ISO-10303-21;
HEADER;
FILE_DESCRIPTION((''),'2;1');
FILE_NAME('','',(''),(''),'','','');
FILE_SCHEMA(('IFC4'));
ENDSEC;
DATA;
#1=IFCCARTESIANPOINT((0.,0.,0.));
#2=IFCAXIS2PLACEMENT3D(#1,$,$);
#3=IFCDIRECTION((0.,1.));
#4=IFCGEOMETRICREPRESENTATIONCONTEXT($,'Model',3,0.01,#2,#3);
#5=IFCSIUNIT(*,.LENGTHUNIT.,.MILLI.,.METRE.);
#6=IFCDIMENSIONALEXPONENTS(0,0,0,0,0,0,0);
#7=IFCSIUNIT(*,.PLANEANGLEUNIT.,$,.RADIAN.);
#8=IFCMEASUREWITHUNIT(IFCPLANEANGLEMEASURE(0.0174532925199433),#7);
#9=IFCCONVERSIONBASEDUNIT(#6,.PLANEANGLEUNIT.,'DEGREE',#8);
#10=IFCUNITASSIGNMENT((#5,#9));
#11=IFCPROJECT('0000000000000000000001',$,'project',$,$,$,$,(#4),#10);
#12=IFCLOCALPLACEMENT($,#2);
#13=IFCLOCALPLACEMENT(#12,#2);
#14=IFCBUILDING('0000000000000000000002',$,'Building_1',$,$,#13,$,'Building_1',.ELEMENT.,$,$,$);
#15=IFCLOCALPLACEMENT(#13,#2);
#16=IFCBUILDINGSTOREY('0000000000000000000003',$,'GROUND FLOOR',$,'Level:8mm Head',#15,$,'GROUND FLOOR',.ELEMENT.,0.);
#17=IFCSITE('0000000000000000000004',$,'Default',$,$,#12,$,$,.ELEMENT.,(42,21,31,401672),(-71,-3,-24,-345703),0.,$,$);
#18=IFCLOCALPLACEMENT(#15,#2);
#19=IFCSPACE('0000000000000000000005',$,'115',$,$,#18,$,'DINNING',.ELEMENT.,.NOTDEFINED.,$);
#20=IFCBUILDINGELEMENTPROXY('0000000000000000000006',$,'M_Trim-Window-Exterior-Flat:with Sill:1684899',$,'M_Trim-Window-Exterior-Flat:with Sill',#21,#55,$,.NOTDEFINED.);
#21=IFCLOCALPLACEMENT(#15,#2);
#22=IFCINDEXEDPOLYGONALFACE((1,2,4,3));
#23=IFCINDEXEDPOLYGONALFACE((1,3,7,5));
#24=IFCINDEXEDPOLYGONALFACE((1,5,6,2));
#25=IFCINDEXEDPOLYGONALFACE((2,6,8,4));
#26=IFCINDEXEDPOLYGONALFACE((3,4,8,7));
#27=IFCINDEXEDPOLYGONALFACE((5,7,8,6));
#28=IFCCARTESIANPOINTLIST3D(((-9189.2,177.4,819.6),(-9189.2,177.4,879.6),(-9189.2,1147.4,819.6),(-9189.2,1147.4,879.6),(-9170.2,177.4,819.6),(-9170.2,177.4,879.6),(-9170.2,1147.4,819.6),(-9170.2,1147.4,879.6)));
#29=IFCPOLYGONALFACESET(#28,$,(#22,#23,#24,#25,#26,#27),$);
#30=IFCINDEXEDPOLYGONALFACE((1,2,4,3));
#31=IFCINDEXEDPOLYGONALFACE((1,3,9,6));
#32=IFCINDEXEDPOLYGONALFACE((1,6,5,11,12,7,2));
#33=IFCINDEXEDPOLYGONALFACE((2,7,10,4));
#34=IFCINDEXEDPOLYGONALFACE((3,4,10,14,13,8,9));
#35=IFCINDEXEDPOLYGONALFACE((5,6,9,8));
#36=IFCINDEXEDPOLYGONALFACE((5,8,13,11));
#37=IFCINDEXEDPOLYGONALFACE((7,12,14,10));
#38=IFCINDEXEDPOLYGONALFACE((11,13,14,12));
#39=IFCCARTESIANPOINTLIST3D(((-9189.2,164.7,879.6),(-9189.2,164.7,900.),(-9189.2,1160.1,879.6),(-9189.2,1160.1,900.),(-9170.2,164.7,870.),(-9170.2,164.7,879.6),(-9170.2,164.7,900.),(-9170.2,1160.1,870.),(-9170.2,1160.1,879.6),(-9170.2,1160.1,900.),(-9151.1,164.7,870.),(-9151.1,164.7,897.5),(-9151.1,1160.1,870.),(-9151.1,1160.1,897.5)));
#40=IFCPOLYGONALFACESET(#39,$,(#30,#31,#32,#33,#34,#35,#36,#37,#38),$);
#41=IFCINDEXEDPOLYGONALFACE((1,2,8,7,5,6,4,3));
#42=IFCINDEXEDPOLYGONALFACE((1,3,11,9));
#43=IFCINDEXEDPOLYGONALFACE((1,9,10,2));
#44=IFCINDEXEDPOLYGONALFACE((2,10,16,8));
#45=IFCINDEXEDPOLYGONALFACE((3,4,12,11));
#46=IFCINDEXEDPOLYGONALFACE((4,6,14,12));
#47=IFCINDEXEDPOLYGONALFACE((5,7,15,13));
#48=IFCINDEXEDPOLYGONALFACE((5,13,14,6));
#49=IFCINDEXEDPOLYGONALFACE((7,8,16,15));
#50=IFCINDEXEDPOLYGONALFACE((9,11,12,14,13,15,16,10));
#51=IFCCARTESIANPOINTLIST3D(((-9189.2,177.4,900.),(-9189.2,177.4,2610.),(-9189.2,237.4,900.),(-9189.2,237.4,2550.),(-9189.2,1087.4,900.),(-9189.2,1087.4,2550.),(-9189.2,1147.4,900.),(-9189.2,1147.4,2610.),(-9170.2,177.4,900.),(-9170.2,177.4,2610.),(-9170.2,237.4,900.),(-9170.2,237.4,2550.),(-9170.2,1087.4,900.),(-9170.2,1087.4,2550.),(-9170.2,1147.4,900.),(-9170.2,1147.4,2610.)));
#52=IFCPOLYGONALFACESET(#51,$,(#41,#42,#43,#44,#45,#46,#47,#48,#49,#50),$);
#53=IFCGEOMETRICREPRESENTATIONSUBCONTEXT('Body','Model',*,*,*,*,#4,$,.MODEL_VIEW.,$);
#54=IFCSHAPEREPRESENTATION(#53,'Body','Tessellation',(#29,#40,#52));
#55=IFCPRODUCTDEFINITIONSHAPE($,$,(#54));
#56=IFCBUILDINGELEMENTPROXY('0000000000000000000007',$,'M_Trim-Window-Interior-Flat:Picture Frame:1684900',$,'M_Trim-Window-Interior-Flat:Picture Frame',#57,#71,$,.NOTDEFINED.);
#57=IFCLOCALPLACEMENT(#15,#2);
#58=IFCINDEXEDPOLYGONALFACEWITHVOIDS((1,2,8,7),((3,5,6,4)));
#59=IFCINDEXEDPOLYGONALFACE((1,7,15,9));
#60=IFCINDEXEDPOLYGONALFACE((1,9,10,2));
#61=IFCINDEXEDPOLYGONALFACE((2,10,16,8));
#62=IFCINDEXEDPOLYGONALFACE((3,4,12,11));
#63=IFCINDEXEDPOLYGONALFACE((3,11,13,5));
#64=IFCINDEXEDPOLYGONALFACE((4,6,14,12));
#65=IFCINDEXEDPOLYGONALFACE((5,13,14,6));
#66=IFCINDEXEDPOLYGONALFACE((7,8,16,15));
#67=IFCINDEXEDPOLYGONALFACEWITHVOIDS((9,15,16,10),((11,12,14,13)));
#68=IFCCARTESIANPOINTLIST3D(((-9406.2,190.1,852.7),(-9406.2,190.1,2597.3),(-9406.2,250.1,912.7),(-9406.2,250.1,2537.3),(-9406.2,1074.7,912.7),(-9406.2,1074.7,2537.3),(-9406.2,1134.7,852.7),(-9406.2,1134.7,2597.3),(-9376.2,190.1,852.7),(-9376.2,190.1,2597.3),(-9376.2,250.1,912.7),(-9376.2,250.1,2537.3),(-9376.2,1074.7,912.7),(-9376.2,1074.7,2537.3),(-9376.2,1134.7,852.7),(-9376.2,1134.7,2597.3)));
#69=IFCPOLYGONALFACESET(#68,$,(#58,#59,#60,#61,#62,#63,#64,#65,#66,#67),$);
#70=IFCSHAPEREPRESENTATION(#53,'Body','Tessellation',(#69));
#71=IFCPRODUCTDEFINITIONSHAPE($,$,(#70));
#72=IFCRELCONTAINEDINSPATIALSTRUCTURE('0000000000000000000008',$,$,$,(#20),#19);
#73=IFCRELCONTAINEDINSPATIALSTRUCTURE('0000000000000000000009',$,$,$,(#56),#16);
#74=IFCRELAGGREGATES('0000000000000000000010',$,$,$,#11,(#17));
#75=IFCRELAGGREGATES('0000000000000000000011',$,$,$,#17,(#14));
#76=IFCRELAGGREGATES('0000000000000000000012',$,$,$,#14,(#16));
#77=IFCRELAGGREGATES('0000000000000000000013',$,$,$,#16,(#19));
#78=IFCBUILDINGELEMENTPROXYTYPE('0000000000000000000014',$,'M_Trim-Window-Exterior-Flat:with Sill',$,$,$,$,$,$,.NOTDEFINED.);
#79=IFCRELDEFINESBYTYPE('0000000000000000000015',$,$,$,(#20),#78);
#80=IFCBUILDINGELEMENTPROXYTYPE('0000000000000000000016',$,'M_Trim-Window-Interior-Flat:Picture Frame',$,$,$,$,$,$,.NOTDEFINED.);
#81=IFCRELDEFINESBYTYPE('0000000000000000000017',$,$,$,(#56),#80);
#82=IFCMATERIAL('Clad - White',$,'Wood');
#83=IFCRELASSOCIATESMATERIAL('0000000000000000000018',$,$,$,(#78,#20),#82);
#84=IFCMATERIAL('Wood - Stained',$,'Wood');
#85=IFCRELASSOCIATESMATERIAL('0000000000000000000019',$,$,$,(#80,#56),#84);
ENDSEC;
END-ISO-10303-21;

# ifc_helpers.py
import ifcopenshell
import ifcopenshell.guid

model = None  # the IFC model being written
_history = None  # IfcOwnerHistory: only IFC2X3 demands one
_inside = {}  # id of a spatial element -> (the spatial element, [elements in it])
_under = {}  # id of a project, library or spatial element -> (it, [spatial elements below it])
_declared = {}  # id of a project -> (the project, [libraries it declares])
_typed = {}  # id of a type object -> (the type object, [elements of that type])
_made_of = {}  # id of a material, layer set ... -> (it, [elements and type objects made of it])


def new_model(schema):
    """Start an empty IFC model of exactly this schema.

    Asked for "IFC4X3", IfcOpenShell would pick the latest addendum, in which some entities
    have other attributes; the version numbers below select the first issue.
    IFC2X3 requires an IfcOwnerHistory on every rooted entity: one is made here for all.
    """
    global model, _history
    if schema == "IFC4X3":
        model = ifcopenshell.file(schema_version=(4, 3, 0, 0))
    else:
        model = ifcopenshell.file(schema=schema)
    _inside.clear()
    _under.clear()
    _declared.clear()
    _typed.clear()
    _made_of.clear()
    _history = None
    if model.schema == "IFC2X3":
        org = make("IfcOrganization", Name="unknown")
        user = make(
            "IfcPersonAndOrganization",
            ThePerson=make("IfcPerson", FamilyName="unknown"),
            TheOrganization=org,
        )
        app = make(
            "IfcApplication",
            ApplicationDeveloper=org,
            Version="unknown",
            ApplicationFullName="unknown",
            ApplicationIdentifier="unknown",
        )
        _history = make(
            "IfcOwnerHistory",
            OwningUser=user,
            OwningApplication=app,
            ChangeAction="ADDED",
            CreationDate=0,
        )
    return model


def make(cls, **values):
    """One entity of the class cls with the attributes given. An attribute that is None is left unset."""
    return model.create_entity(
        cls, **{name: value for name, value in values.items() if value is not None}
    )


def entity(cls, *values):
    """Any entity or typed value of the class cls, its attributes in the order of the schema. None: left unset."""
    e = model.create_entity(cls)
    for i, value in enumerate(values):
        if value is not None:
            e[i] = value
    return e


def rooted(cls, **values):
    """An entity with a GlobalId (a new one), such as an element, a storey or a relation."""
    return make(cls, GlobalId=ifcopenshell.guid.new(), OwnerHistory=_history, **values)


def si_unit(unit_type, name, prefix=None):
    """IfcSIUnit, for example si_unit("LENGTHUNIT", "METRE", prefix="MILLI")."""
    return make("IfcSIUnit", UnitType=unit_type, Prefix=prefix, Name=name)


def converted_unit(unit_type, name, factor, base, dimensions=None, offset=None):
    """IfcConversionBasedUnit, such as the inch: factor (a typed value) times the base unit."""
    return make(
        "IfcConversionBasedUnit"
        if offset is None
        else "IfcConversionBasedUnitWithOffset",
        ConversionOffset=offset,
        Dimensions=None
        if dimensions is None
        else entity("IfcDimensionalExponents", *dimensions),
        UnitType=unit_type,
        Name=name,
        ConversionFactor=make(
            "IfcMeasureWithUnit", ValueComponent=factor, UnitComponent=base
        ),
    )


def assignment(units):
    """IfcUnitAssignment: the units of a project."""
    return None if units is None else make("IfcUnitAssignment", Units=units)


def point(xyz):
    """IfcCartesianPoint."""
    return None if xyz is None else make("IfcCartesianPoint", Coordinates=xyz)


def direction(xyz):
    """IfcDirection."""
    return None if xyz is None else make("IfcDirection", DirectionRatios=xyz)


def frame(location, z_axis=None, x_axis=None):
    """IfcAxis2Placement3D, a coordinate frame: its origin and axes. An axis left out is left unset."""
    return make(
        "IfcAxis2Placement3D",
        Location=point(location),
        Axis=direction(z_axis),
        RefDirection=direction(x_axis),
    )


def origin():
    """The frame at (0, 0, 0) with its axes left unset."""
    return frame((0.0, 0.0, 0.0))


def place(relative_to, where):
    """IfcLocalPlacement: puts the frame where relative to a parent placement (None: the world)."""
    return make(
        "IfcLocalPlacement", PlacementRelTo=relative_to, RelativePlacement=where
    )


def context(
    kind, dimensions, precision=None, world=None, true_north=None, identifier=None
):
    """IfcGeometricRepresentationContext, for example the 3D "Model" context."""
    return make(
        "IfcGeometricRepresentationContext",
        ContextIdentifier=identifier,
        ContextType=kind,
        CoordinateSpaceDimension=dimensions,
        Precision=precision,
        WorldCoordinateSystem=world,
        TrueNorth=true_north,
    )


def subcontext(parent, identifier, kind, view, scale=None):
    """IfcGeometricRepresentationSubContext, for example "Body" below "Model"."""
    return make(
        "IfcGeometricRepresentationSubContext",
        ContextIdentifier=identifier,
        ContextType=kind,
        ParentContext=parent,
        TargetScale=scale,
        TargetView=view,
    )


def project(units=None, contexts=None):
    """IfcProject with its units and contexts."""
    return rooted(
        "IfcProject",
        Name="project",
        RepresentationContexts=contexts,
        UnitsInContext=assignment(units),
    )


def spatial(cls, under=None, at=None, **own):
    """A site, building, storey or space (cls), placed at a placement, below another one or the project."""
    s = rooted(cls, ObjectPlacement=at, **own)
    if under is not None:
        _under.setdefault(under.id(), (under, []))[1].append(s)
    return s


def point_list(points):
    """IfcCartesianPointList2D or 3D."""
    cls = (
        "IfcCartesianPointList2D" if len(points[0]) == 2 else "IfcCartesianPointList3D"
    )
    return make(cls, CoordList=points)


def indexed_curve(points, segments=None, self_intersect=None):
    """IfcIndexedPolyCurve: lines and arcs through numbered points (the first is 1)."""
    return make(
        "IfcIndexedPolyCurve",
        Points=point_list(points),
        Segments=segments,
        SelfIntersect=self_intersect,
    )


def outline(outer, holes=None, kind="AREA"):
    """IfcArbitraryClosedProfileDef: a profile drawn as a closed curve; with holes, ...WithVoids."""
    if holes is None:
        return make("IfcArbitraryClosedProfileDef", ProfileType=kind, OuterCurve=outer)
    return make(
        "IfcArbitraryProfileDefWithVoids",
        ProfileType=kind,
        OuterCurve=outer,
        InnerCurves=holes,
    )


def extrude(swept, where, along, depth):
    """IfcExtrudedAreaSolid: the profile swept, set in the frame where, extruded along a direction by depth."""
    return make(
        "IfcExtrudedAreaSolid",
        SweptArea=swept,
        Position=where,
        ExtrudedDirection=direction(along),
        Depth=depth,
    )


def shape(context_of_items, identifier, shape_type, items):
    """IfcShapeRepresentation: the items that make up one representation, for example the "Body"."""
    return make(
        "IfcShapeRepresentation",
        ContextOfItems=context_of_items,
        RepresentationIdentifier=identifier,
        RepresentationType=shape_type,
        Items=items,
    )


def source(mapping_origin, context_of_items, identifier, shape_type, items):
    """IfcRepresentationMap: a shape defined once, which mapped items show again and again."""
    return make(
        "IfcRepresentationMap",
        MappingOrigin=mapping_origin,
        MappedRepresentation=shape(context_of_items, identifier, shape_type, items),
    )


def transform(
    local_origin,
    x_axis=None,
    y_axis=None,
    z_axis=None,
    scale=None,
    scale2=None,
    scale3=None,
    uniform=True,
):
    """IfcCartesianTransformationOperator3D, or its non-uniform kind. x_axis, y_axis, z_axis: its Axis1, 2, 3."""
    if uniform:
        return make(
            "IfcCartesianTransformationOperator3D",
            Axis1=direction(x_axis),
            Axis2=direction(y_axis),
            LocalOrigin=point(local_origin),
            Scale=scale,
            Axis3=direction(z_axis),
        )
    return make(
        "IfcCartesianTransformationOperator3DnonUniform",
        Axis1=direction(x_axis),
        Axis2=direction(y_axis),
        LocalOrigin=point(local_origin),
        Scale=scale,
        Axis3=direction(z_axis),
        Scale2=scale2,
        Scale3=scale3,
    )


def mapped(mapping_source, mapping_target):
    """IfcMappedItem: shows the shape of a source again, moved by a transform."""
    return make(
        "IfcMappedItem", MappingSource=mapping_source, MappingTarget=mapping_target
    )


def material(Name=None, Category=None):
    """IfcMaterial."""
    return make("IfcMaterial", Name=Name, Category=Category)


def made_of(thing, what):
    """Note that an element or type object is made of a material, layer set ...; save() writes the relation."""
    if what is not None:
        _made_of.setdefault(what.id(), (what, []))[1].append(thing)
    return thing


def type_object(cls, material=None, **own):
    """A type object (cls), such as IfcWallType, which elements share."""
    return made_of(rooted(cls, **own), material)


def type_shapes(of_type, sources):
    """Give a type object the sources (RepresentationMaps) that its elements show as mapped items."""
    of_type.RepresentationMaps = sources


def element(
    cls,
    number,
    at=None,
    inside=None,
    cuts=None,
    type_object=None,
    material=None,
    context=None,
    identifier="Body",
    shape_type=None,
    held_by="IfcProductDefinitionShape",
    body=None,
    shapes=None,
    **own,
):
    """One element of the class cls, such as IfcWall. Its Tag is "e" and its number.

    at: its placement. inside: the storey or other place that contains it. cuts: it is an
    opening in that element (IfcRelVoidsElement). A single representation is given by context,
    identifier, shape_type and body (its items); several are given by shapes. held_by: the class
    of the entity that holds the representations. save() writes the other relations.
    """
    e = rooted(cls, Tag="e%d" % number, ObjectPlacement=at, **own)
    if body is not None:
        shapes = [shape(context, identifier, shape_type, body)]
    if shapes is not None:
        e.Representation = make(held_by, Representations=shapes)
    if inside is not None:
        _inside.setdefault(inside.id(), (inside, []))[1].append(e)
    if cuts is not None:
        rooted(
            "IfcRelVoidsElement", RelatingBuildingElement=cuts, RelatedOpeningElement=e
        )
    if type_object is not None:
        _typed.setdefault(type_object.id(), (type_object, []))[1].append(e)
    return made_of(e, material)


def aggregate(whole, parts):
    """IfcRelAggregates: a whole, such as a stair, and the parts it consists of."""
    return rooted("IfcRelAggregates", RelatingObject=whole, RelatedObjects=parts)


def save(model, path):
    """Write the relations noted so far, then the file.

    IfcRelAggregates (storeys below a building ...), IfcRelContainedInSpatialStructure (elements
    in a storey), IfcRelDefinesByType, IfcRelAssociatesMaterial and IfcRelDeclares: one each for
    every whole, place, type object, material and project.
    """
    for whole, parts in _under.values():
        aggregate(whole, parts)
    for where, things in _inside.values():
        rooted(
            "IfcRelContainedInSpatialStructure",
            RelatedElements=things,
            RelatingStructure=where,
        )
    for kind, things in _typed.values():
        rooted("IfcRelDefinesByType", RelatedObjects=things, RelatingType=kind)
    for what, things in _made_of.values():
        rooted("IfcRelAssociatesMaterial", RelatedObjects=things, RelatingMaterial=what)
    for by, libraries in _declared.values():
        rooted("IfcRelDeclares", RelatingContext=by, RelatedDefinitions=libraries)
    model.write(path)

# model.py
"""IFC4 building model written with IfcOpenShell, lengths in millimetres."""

from ifc_helpers import new_model, entity, si_unit, converted_unit, direction, frame, origin, place, context, subcontext, project, spatial, indexed_curve, outline, extrude, source, transform, mapped, material, type_object, type_shapes, element, save


model = new_model("IFC4")

# Units and contexts
model_context = context("Model", 3, precision=0.01, world=origin(), true_north=direction((0.0, 1.0)))
body_context = subcontext(model_context, "Body", "Model", "MODEL_VIEW")
ifc_project = project(units=[si_unit("LENGTHUNIT", "METRE", prefix="MILLI"), converted_unit("PLANEANGLEUNIT", "DEGREE", entity("IfcPlaneAngleMeasure", 0.0174532925199433), si_unit("PLANEANGLEUNIT", "RADIAN"), dimensions=[0, 0, 0, 0, 0, 0, 0])], contexts=[model_context])

# Site, building, storey
site_placement = place(None, origin())
site = spatial("IfcSite", under=ifc_project, at=site_placement, Name="Default", CompositionType="ELEMENT", RefLatitude=(42, 21, 31, 401672), RefLongitude=(-71, -3, -24, -345703), RefElevation=0.0)
building_placement = place(site_placement, origin())
building = spatial("IfcBuilding", under=site, at=building_placement, Name="Building_1", LongName="Building_1", CompositionType="ELEMENT")
storey_placement = place(building_placement, origin())
storey = spatial("IfcBuildingStorey", under=building, at=storey_placement, Name="GROUND FLOOR", ObjectType="Level:8mm Head", LongName="GROUND FLOOR", CompositionType="ELEMENT", Elevation=0.0)

# Shared definitions
ifc_material_1 = material(Name="Wood - Stained", Category="Wood")

# Shared definitions
ifc_material_2 = material(Name="Clad - White", Category="Wood")

# Shared definitions
space_1_placement = place(storey_placement, origin())
space_1 = spatial("IfcSpace", under=storey, at=space_1_placement, Name="115", LongName="DINNING", CompositionType="ELEMENT", PredefinedType="NOTDEFINED")

# Building element proxies
building_element_proxy_type_1 = type_object("IfcBuildingElementProxyType", Name="M_Trim-Window-Exterior-Flat:with Sill", PredefinedType="NOTDEFINED", material=ifc_material_2)
shared_shape_1 = source(origin(), body_context, "Body", "SweptSolid", [
    extrude(outline(indexed_curve([(-485.0, -30.0), (485.0, -30.0), (485.0, 30.0), (-485.0, 30.0), (-485.0, -30.0)], self_intersect=False)), frame((0.0, -1700.4, 0.0), z_axis=(0.0, 0.0, 1.0), x_axis=(-1.0, 0.0, 0.0)), (0.0, 0.0, 1.0), 19.1),
    extrude(outline(indexed_curve([(-19.0, -15.2), (0.0, -15.2), (0.0, -5.7), (19.0, -5.7), (19.0, 14.8), (0.0, 14.8), (-19.0, 12.3), (-19.0, -15.2)], self_intersect=False)), frame((-497.7, -1664.8, 19.0), z_axis=(1.0, 0.0, 0.0), x_axis=(0.0, 0.0, -1.0)), (0.0, 0.0, 1.0), 995.4),
    extrude(outline(indexed_curve([(-870.0, -485.0), (840.0, -485.0), (840.0, -425.0), (-810.0, -425.0), (-810.0, 425.0), (840.0, 425.0), (840.0, 485.0), (-870.0, 485.0), (-870.0, -485.0)], self_intersect=False)), frame((0.0, -810.0, 0.0), z_axis=(0.0, 0.0, 1.0), x_axis=(0.0, -1.0, 0.0)), (0.0, 0.0, 1.0), 19.1),
])
type_shapes(building_element_proxy_type_1, [shared_shape_1])
proxy_1_placement = place(space_1_placement, frame((-9189.2, 662.4, 2550.0), z_axis=(1.0, 0.0, 0.0), x_axis=(0.0, 1.0, 0.0)))
element("IfcBuildingElementProxy", 1, at=proxy_1_placement, inside=space_1, type_object=building_element_proxy_type_1, material=ifc_material_2, Name="M_Trim-Window-Exterior-Flat:with Sill:1684899", ObjectType="M_Trim-Window-Exterior-Flat:with Sill", PredefinedType="NOTDEFINED", context=body_context, shape_type="MappedRepresentation", body=[
    mapped(shared_shape_1, transform((0.0, 0.0, 0.0), scale=1.0)),
])
building_element_proxy_type_2 = type_object("IfcBuildingElementProxyType", Name="M_Trim-Window-Interior-Flat:Picture Frame", PredefinedType="NOTDEFINED", material=ifc_material_1)
shared_shape_2 = source(origin(), body_context, "Body", "SweptSolid", [
    extrude(outline(indexed_curve([(-472.3, -872.3), (472.3, -872.3), (472.3, 872.3), (-472.3, 872.3), (-472.3, -872.3)], self_intersect=False), holes=[indexed_curve([(-412.3, -812.3), (-412.3, 812.3), (412.3, 812.3), (412.3, -812.3), (-412.3, -812.3)], self_intersect=False)]), frame((0.0, -825.0, 0.0), z_axis=(0.0, 0.0, 1.0), x_axis=(-1.0, 0.0, 0.0)), (0.0, 0.0, 1.0), 30.0),
])
type_shapes(building_element_proxy_type_2, [shared_shape_2])
proxy_2_placement = place(storey_placement, frame((-9376.2, 662.4, 2550.0), z_axis=(-1.0, 0.0, 0.0), x_axis=(0.0, -1.0, 0.0)))
element("IfcBuildingElementProxy", 2, at=proxy_2_placement, inside=storey, type_object=building_element_proxy_type_2, material=ifc_material_1, Name="M_Trim-Window-Interior-Flat:Picture Frame:1684900", ObjectType="M_Trim-Window-Interior-Flat:Picture Frame", PredefinedType="NOTDEFINED", context=body_context, shape_type="MappedRepresentation", body=[
    mapped(shared_shape_2, transform((0.0, 0.0, 0.0), scale=1.0)),
])

save(model, "model.ifc")
